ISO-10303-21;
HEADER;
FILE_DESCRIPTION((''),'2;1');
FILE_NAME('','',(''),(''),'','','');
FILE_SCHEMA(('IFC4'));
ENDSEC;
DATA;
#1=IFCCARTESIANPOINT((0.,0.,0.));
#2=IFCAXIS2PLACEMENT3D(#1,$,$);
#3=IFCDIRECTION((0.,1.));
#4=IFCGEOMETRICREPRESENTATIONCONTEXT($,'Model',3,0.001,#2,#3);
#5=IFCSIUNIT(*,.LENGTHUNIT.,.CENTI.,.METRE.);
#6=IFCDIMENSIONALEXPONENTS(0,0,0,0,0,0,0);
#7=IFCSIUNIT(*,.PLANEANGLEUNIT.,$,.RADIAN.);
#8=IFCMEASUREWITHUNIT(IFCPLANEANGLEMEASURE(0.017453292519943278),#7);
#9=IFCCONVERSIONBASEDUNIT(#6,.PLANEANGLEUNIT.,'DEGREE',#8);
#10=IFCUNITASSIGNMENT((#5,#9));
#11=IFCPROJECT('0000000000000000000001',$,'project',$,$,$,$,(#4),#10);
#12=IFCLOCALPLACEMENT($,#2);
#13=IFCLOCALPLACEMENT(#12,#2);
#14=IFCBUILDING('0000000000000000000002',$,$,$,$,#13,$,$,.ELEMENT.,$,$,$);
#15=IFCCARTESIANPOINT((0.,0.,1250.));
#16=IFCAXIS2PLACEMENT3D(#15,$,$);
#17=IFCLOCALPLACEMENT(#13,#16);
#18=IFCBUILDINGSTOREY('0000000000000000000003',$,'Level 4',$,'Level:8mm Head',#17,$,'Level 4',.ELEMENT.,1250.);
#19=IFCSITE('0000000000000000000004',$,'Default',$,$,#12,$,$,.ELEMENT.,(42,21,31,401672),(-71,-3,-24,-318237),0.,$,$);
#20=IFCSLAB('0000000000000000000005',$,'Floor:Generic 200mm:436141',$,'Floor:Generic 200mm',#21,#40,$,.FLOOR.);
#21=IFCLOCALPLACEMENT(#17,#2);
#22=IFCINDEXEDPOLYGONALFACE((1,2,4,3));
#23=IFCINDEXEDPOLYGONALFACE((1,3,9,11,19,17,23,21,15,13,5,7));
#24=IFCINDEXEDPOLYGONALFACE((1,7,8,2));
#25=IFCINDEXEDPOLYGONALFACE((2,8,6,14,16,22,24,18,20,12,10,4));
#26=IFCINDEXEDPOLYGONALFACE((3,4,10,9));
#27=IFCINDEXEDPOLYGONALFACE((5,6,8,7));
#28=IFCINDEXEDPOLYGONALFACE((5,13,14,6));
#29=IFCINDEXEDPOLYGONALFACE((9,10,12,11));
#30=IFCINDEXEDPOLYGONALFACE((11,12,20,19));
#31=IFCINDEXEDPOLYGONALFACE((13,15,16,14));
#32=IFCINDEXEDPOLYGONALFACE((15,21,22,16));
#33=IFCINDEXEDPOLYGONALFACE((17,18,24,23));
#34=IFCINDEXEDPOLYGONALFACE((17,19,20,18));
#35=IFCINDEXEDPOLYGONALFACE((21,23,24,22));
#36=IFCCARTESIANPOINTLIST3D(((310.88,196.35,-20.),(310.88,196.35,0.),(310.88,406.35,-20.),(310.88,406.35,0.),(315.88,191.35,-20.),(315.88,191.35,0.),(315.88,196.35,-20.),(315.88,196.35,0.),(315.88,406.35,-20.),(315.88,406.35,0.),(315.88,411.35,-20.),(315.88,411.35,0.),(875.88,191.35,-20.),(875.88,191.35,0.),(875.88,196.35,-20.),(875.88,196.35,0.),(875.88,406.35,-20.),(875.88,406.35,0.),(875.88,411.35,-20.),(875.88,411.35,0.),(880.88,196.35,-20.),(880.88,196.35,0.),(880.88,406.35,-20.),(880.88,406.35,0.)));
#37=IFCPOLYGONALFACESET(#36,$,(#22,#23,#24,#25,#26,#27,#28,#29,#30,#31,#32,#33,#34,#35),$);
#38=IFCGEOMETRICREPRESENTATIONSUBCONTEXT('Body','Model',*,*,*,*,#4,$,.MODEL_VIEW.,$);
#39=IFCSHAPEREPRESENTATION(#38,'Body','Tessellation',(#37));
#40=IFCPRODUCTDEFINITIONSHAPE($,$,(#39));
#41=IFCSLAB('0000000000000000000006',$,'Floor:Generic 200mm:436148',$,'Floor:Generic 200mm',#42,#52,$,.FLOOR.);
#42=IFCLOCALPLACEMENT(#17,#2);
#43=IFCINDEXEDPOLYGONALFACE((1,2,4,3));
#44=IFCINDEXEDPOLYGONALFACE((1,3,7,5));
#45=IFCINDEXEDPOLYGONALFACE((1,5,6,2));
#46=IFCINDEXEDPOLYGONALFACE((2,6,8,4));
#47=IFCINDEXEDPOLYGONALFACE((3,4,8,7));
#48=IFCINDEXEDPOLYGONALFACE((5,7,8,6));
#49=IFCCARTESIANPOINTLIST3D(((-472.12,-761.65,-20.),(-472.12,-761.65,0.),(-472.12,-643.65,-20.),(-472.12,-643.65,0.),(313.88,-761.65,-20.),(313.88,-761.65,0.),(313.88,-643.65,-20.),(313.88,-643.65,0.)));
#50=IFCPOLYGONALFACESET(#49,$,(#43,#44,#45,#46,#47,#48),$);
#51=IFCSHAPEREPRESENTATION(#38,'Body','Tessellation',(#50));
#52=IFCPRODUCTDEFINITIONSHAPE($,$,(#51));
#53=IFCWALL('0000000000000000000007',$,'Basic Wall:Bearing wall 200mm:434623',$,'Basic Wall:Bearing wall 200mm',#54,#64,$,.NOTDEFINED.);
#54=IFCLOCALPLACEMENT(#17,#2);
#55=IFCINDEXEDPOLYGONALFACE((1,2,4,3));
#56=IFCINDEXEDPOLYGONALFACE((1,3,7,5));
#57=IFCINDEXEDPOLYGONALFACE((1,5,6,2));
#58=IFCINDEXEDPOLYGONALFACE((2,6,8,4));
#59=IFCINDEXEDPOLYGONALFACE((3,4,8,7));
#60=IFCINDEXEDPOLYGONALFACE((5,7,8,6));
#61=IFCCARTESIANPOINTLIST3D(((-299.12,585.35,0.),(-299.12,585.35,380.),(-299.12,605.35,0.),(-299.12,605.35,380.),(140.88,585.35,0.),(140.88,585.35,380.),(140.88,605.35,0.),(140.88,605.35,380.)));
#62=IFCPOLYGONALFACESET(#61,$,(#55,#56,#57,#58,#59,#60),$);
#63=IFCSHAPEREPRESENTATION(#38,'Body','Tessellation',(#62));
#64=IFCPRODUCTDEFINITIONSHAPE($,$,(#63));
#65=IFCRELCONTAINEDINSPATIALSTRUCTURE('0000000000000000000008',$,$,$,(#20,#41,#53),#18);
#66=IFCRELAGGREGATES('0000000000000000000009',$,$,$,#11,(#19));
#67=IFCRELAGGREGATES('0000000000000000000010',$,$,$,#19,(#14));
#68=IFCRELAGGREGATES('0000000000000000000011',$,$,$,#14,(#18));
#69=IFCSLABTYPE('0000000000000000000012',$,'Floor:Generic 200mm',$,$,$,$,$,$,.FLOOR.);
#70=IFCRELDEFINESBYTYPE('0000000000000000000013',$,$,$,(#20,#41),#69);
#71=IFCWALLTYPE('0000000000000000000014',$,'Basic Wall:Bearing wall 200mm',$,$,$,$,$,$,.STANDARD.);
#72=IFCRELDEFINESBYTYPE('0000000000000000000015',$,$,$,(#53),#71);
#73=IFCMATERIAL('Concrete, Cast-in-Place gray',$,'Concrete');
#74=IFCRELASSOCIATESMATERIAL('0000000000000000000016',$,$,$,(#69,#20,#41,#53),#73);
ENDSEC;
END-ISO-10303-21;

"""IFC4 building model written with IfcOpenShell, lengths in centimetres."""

from ifc_helpers import new_model, entity, si_unit, converted_unit, direction, frame, origin, place, context, subcontext, project, spatial, indexed_curve, outline, extrude, material, type_object, element, save


model = new_model("IFC4")

# Units and contexts
model_context = context("Model", 3, precision=0.001, world=origin(), true_north=direction((0.0, 1.0)))
body_context = subcontext(model_context, "Body", "Model", "MODEL_VIEW")
ifc_project = project(units=[si_unit("LENGTHUNIT", "METRE", prefix="CENTI"), converted_unit("PLANEANGLEUNIT", "DEGREE", entity("IfcPlaneAngleMeasure", 0.017453292519943278), si_unit("PLANEANGLEUNIT", "RADIAN"), dimensions=[0, 0, 0, 0, 0, 0, 0])], contexts=[model_context])

# Site, building, storey
site_placement = place(None, origin())
site = spatial("IfcSite", under=ifc_project, at=site_placement, Name="Default", CompositionType="ELEMENT", RefLatitude=(42, 21, 31, 401672), RefLongitude=(-71, -3, -24, -318237), RefElevation=0.0)
building_placement = place(site_placement, origin())
building = spatial("IfcBuilding", under=site, at=building_placement, CompositionType="ELEMENT")
storey_placement = place(building_placement, frame((0.0, 0.0, 1250.0)))
storey = spatial("IfcBuildingStorey", under=building, at=storey_placement, Name="Level 4", ObjectType="Level:8mm Head", LongName="Level 4", CompositionType="ELEMENT", Elevation=1250.0)

# Shared definitions
ifc_material = material(Name="Concrete, Cast-in-Place gray", Category="Concrete")
slab_type = type_object("IfcSlabType", Name="Floor:Generic 200mm", PredefinedType="FLOOR", material=ifc_material)

# Slabs
slab_1_placement = place(storey_placement, origin())
element("IfcSlab", 1, at=slab_1_placement, inside=storey, type_object=slab_type, material=ifc_material, Name="Floor:Generic 200mm:436141", ObjectType="Floor:Generic 200mm", PredefinedType="FLOOR", context=body_context, shape_type="SweptSolid", body=[
    extrude(outline(indexed_curve([(-105.0, -285.0), (105.0, -285.0), (105.0, -280.0), (110.0, -280.0), (110.0, 280.0), (105.0, 280.0), (105.0, 285.0), (-105.0, 285.0), (-105.0, 280.0), (-110.0, 280.0), (-110.0, -280.0), (-105.0, -280.0), (-105.0, -285.0)], self_intersect=False)), frame((595.88, 301.35, 0.0), z_axis=(0.0, 0.0, -1.0), x_axis=(0.0, 1.0, 0.0)), (0.0, 0.0, 1.0), 20.0),
])
slab_2_placement = place(storey_placement, origin())
element("IfcSlab", 2, at=slab_2_placement, inside=storey, type_object=slab_type, material=ifc_material, Name="Floor:Generic 200mm:436148", ObjectType="Floor:Generic 200mm", PredefinedType="FLOOR", context=body_context, shape_type="SweptSolid", body=[
    extrude(outline(indexed_curve([(-59.0, -393.0), (59.0, -393.0), (59.0, 393.0), (-59.0, 393.0), (-59.0, -393.0)], self_intersect=False)), frame((-79.12, -702.65, 0.0), z_axis=(0.0, 0.0, -1.0), x_axis=(0.0, 1.0, 0.0)), (0.0, 0.0, 1.0), 20.0),
])

# Wall
wall_type = type_object("IfcWallType", Name="Basic Wall:Bearing wall 200mm", PredefinedType="STANDARD")
wall_placement = place(storey_placement, frame((-299.12, 595.35, 0.0)))
element("IfcWall", 3, at=wall_placement, inside=storey, type_object=wall_type, material=ifc_material, Name="Basic Wall:Bearing wall 200mm:434623", ObjectType="Basic Wall:Bearing wall 200mm", PredefinedType="NOTDEFINED", context=body_context, shape_type="SweptSolid", body=[
    extrude(outline(indexed_curve([(440.0, 10.0), (0.0, 10.0), (0.0, -10.0), (440.0, -10.0), (440.0, 10.0)], self_intersect=False)), origin(), (0.0, 0.0, 1.0), 380.0),
])

save(model, "model.ifc")
